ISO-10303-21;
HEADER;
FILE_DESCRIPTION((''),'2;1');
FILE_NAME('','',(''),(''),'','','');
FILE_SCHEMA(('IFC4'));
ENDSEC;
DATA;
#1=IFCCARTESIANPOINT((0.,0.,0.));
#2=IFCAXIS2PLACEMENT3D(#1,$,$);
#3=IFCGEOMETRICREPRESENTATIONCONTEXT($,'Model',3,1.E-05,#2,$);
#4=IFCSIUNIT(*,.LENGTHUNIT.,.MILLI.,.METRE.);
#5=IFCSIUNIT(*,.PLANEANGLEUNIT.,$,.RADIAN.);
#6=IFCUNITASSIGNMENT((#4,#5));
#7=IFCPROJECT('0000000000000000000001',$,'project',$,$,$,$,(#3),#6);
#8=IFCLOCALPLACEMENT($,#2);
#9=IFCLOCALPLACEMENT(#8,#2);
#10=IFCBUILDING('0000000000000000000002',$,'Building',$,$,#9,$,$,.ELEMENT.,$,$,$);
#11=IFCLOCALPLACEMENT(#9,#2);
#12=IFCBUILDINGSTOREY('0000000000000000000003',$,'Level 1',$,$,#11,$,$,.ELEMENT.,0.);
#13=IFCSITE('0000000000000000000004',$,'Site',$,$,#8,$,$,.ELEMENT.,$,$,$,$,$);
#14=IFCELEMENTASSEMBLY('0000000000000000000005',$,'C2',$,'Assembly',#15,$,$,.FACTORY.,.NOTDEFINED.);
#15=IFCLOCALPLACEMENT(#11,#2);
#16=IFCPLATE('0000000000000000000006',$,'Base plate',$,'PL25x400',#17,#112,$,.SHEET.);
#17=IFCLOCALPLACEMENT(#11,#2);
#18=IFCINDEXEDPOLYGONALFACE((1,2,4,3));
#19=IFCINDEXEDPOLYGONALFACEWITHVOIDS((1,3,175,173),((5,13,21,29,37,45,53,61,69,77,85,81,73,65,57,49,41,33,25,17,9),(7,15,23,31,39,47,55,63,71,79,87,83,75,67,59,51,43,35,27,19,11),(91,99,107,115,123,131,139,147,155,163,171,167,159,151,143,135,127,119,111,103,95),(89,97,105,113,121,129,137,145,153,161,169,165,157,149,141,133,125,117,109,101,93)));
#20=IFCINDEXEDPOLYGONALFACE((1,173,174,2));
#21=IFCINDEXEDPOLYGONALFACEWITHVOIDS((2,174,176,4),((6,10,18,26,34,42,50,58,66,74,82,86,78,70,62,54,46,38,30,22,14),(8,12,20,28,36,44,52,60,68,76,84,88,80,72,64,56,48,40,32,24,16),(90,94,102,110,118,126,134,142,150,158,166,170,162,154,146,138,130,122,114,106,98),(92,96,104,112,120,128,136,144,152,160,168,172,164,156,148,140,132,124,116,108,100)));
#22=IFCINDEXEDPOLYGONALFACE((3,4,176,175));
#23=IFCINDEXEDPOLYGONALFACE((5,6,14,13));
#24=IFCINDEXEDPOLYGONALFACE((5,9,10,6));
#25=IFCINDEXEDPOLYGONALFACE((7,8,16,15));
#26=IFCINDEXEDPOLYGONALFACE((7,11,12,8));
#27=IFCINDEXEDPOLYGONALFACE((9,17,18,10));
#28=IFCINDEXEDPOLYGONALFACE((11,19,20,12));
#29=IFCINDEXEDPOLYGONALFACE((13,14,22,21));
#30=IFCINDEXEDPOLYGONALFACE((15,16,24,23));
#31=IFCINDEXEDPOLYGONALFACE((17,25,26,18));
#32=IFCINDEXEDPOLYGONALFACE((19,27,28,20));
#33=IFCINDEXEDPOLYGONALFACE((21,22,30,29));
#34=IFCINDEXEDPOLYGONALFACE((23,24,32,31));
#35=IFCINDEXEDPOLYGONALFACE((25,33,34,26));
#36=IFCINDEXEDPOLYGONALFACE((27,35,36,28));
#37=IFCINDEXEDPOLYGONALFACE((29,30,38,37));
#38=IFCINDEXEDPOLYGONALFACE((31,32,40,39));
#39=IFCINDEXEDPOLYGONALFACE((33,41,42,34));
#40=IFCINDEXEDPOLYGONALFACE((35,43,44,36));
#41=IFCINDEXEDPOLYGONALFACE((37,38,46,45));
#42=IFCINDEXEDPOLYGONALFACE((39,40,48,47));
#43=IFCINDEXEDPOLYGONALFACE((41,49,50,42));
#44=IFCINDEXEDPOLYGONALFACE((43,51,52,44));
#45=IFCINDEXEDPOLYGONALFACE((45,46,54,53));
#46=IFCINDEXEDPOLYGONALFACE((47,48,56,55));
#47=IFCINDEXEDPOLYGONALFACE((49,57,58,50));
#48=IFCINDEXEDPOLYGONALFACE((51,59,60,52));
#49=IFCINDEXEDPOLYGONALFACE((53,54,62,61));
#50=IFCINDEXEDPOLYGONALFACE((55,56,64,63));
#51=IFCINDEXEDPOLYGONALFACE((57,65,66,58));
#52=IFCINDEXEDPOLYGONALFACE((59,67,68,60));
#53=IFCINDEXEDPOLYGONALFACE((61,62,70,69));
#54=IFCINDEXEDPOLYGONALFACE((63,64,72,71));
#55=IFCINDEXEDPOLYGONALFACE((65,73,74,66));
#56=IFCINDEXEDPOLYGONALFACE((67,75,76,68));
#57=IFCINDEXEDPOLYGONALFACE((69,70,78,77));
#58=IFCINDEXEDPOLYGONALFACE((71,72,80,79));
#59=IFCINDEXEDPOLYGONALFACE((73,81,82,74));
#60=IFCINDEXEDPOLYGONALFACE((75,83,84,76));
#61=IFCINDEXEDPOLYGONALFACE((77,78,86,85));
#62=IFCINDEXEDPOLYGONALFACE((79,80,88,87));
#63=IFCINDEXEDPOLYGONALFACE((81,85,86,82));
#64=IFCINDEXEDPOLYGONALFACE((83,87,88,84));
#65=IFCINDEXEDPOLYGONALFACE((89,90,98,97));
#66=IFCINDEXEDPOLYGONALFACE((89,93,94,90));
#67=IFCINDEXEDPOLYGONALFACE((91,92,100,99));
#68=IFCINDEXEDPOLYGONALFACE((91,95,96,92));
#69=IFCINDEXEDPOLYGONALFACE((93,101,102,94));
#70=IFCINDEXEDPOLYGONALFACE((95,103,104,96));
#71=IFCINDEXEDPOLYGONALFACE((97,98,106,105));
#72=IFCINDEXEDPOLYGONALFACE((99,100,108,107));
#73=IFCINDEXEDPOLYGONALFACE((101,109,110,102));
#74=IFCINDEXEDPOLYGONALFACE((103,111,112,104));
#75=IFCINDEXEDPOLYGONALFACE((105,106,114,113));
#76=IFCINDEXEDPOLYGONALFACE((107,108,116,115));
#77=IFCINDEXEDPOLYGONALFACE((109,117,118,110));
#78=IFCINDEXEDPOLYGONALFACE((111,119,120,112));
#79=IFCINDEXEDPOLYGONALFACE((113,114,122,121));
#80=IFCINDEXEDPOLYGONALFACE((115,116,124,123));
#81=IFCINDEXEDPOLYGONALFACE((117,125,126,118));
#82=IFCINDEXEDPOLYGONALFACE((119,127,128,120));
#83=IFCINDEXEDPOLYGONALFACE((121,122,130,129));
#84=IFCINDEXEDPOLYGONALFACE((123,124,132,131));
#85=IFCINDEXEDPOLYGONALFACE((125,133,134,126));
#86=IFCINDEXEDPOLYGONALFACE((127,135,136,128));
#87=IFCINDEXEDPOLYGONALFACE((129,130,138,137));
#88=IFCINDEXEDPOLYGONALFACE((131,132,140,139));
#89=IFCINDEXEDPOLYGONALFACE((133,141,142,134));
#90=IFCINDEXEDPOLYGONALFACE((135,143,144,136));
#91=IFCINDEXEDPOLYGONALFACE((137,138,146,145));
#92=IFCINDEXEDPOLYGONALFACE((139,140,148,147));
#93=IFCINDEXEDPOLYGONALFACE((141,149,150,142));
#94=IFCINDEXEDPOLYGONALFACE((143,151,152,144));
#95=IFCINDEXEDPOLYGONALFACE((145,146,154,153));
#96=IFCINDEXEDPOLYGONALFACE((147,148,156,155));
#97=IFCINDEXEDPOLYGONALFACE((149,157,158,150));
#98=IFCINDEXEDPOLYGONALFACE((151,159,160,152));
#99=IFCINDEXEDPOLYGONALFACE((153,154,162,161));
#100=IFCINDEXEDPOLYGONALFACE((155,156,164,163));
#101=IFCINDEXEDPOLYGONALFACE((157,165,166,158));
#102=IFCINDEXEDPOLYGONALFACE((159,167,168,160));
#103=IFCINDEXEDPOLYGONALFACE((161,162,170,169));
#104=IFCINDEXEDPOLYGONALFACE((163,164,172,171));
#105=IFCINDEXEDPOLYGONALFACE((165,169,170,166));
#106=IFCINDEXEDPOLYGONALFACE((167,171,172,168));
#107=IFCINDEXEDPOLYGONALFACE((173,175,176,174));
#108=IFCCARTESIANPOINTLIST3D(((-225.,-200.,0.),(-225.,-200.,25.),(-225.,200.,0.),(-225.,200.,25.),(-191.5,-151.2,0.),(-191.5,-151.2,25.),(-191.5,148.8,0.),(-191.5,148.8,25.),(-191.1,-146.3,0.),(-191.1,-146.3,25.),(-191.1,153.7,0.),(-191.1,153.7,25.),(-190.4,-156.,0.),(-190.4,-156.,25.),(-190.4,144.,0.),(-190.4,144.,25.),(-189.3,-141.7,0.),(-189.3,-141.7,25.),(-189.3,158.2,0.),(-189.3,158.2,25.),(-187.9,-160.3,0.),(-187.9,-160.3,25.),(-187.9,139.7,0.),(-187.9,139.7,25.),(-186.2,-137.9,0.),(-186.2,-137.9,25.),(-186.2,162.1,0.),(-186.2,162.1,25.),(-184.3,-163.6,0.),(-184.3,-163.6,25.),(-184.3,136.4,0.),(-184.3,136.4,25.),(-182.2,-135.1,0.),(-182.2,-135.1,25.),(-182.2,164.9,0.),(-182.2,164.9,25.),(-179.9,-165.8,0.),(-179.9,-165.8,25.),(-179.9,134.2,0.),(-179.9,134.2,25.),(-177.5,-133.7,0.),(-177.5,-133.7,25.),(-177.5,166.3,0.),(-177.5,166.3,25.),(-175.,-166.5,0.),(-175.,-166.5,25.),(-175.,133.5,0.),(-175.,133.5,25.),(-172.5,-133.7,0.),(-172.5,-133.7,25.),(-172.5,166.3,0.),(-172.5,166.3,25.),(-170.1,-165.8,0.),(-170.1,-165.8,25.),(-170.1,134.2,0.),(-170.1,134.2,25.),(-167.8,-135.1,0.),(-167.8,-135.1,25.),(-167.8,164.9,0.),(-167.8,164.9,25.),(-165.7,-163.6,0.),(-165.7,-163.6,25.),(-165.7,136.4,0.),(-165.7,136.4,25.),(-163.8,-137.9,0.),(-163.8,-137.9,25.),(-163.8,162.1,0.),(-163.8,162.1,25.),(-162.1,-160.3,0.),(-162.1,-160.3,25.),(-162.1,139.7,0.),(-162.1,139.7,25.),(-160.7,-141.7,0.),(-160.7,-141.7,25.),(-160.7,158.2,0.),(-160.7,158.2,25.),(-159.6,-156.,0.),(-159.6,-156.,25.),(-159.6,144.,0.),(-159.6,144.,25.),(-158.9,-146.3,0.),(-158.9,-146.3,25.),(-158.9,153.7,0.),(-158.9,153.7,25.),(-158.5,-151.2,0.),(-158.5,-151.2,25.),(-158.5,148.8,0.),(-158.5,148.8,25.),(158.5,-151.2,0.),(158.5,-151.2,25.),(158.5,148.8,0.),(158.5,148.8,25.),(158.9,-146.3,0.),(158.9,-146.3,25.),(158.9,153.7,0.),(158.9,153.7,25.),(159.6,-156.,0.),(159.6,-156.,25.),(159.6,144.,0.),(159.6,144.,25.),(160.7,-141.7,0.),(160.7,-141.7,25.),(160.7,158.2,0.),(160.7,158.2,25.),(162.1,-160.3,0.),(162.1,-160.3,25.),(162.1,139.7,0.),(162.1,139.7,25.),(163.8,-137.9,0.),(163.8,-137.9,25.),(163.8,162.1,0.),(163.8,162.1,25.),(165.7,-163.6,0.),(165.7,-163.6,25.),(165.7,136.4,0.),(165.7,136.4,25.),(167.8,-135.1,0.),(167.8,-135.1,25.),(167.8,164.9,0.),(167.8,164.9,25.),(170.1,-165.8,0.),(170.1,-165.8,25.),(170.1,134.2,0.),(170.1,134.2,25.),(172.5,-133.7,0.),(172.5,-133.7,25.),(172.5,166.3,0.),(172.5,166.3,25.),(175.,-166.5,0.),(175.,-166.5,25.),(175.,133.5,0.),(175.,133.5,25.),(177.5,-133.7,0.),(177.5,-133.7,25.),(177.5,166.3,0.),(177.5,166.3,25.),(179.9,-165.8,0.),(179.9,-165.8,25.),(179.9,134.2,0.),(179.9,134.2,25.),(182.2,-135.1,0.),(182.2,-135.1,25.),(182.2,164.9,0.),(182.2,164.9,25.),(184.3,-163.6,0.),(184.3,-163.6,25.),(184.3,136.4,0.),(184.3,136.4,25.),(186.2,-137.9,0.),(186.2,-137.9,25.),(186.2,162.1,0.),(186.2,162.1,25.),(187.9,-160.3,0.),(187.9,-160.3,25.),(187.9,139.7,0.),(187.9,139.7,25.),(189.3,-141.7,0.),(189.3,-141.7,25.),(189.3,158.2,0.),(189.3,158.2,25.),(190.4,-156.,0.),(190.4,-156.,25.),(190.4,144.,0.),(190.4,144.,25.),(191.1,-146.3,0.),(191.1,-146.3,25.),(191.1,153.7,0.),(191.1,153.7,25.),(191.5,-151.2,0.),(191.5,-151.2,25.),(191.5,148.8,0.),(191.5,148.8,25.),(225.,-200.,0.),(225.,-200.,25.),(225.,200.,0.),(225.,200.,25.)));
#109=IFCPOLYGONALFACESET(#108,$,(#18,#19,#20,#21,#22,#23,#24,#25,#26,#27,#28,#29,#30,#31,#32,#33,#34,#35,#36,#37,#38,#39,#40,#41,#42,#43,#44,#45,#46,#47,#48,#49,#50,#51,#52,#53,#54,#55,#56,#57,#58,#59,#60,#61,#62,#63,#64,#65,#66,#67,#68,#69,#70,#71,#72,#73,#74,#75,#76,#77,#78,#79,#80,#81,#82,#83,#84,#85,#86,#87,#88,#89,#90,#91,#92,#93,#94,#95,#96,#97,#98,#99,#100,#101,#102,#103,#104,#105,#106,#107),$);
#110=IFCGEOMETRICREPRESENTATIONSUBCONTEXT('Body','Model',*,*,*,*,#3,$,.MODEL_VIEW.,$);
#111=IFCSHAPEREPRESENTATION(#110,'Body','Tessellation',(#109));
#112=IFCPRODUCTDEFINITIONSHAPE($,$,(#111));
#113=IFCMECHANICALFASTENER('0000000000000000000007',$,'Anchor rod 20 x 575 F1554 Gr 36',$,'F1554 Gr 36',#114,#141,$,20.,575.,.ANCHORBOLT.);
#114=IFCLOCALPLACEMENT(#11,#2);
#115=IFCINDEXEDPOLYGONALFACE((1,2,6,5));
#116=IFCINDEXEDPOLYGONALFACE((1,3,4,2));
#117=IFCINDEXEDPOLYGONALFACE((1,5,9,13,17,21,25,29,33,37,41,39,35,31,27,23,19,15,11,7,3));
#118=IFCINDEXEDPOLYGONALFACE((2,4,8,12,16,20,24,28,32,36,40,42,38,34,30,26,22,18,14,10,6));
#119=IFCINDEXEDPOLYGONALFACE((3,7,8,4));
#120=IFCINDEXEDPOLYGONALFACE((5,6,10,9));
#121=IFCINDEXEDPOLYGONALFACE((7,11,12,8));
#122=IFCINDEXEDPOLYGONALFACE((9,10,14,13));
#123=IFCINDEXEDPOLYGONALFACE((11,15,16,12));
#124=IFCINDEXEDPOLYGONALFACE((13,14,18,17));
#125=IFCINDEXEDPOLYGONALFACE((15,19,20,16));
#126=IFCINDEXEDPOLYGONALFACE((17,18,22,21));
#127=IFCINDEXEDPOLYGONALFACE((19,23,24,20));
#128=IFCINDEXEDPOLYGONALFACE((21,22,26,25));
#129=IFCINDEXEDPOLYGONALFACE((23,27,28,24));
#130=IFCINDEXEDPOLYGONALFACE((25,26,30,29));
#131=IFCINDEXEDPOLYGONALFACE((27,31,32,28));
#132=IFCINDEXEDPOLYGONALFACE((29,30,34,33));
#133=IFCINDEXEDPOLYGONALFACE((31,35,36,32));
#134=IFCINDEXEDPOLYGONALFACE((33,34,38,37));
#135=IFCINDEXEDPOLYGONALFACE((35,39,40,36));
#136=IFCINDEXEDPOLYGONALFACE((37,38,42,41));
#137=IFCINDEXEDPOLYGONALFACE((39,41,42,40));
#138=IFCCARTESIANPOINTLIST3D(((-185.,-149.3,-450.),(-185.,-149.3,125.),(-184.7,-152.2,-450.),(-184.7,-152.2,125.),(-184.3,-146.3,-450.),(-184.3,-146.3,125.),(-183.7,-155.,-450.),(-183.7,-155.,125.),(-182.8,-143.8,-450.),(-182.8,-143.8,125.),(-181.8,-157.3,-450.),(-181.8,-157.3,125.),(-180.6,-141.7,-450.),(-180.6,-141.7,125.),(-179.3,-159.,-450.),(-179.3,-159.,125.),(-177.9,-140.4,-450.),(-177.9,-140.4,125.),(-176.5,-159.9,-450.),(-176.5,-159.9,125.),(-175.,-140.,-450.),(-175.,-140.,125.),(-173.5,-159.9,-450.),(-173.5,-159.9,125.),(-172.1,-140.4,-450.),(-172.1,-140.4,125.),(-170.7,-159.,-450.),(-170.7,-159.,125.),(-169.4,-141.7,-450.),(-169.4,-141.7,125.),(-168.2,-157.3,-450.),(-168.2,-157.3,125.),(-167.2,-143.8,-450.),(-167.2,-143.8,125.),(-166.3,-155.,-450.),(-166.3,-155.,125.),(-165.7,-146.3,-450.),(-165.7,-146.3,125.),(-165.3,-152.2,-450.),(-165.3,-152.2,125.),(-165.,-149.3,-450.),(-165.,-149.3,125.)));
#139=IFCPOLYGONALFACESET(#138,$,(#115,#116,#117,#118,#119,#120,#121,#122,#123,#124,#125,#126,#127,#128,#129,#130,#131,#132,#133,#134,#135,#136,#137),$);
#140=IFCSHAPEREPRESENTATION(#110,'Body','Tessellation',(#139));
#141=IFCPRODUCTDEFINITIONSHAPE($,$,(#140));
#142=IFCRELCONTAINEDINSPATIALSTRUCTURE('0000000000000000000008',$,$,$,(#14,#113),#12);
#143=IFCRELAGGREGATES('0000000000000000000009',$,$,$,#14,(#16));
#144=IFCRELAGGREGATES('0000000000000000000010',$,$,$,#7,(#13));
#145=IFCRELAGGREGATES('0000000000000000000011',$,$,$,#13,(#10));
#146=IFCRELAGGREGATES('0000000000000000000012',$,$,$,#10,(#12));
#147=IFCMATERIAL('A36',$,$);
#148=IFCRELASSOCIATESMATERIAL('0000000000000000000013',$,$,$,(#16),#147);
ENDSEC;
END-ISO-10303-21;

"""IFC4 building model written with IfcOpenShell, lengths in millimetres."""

from ifc_helpers import new_model, si_unit, frame, origin, origin_2d, place, context, subcontext, project, spatial, rectangle, circle, extrude, material, element, aggregate, save


model = new_model("IFC4")

# Units and contexts
model_context = context("Model", 3, precision=1e-05, world=origin())
body_context = subcontext(model_context, "Body", "Model", "MODEL_VIEW")
ifc_project = project(units=[si_unit("LENGTHUNIT", "METRE", prefix="MILLI"), si_unit("PLANEANGLEUNIT", "RADIAN")], contexts=[model_context])

# Site, building, storey
site_placement = place(None, origin())
site = spatial("IfcSite", under=ifc_project, at=site_placement, Name="Site", CompositionType="ELEMENT")
building_placement = place(site_placement, origin())
building = spatial("IfcBuilding", under=site, at=building_placement, Name="Building", CompositionType="ELEMENT")
storey_placement = place(building_placement, origin())
storey = spatial("IfcBuildingStorey", under=building, at=storey_placement, Name="Level 1", CompositionType="ELEMENT", Elevation=0.0)

# Element assembly, plate, openings
assembly_placement = place(storey_placement, origin())
assembly = element("IfcElementAssembly", 1, at=assembly_placement, inside=storey, Name="C2", ObjectType="Assembly", AssemblyPlace="FACTORY", PredefinedType="NOTDEFINED")
ifc_material = material(Name="A36")
plate_placement = place(storey_placement, frame((-225.0, 0.0, 12.5), z_axis=(1.0, 0.0, 0.0), x_axis=(0.0, 1.0, 0.0)))
plate = element("IfcPlate", 2, at=plate_placement, material=ifc_material, Name="Base plate", ObjectType="PL25x400", PredefinedType="SHEET", context=body_context, shape_type="SweptSolid", body=[
    extrude(rectangle(XDim=400.0, YDim=25.0, at=origin_2d()), origin(), (0.0, 0.0, 1.0), 450.0),
])
opening_1_placement = place(plate_placement, frame((-150.0, -13.5, 50.0), z_axis=(0.0, 1.0, 0.0), x_axis=(-1.0, 0.0, 0.0)))
element("IfcOpeningElement", 3, at=opening_1_placement, cuts=plate, PredefinedType="OPENING", context=body_context, shape_type="SweptSolid", body=[
    extrude(circle(Radius=16.5, at=origin_2d()), origin(), (0.0, 0.0, 1.0), 27.0),
])
opening_2_placement = place(plate_placement, frame((150.0, -13.5, 50.0), z_axis=(0.0, 1.0, 0.0), x_axis=(-1.0, 0.0, 0.0)))
element("IfcOpeningElement", 4, at=opening_2_placement, cuts=plate, PredefinedType="OPENING", context=body_context, shape_type="SweptSolid", body=[
    extrude(circle(Radius=16.5, at=origin_2d()), origin(), (0.0, 0.0, 1.0), 27.0),
])
opening_3_placement = place(plate_placement, frame((-150.0, -13.5, 400.0), z_axis=(0.0, 1.0, 0.0), x_axis=(-1.0, 0.0, 0.0)))
element("IfcOpeningElement", 5, at=opening_3_placement, cuts=plate, PredefinedType="OPENING", context=body_context, shape_type="SweptSolid", body=[
    extrude(circle(Radius=16.5, at=origin_2d()), origin(), (0.0, 0.0, 1.0), 27.0),
])
opening_4_placement = place(plate_placement, frame((150.0, -13.5, 400.0), z_axis=(0.0, 1.0, 0.0), x_axis=(-1.0, 0.0, 0.0)))
element("IfcOpeningElement", 6, at=opening_4_placement, cuts=plate, PredefinedType="OPENING", context=body_context, shape_type="SweptSolid", body=[
    extrude(circle(Radius=16.5, at=origin_2d()), origin(), (0.0, 0.0, 1.0), 27.0),
])
aggregate(assembly, [plate])

# Mechanical fastener
mechanical_fastener_placement = place(storey_placement, frame((-175.0, -150.0, 125.0), z_axis=(0.0, 0.0, -1.0), x_axis=(0.0, 1.0, 0.0)))
element("IfcMechanicalFastener", 7, at=mechanical_fastener_placement, inside=storey, Name="Anchor rod 20 x 575 F1554 Gr 36", ObjectType="F1554 Gr 36", NominalDiameter=20.0, NominalLength=575.0, PredefinedType="ANCHORBOLT", context=body_context, shape_type="SweptSolid", body=[
    extrude(circle(Radius=10.0, at=origin_2d()), origin(), (0.0, 0.0, 1.0), 575.0),
])

save(model, "model.ifc")
